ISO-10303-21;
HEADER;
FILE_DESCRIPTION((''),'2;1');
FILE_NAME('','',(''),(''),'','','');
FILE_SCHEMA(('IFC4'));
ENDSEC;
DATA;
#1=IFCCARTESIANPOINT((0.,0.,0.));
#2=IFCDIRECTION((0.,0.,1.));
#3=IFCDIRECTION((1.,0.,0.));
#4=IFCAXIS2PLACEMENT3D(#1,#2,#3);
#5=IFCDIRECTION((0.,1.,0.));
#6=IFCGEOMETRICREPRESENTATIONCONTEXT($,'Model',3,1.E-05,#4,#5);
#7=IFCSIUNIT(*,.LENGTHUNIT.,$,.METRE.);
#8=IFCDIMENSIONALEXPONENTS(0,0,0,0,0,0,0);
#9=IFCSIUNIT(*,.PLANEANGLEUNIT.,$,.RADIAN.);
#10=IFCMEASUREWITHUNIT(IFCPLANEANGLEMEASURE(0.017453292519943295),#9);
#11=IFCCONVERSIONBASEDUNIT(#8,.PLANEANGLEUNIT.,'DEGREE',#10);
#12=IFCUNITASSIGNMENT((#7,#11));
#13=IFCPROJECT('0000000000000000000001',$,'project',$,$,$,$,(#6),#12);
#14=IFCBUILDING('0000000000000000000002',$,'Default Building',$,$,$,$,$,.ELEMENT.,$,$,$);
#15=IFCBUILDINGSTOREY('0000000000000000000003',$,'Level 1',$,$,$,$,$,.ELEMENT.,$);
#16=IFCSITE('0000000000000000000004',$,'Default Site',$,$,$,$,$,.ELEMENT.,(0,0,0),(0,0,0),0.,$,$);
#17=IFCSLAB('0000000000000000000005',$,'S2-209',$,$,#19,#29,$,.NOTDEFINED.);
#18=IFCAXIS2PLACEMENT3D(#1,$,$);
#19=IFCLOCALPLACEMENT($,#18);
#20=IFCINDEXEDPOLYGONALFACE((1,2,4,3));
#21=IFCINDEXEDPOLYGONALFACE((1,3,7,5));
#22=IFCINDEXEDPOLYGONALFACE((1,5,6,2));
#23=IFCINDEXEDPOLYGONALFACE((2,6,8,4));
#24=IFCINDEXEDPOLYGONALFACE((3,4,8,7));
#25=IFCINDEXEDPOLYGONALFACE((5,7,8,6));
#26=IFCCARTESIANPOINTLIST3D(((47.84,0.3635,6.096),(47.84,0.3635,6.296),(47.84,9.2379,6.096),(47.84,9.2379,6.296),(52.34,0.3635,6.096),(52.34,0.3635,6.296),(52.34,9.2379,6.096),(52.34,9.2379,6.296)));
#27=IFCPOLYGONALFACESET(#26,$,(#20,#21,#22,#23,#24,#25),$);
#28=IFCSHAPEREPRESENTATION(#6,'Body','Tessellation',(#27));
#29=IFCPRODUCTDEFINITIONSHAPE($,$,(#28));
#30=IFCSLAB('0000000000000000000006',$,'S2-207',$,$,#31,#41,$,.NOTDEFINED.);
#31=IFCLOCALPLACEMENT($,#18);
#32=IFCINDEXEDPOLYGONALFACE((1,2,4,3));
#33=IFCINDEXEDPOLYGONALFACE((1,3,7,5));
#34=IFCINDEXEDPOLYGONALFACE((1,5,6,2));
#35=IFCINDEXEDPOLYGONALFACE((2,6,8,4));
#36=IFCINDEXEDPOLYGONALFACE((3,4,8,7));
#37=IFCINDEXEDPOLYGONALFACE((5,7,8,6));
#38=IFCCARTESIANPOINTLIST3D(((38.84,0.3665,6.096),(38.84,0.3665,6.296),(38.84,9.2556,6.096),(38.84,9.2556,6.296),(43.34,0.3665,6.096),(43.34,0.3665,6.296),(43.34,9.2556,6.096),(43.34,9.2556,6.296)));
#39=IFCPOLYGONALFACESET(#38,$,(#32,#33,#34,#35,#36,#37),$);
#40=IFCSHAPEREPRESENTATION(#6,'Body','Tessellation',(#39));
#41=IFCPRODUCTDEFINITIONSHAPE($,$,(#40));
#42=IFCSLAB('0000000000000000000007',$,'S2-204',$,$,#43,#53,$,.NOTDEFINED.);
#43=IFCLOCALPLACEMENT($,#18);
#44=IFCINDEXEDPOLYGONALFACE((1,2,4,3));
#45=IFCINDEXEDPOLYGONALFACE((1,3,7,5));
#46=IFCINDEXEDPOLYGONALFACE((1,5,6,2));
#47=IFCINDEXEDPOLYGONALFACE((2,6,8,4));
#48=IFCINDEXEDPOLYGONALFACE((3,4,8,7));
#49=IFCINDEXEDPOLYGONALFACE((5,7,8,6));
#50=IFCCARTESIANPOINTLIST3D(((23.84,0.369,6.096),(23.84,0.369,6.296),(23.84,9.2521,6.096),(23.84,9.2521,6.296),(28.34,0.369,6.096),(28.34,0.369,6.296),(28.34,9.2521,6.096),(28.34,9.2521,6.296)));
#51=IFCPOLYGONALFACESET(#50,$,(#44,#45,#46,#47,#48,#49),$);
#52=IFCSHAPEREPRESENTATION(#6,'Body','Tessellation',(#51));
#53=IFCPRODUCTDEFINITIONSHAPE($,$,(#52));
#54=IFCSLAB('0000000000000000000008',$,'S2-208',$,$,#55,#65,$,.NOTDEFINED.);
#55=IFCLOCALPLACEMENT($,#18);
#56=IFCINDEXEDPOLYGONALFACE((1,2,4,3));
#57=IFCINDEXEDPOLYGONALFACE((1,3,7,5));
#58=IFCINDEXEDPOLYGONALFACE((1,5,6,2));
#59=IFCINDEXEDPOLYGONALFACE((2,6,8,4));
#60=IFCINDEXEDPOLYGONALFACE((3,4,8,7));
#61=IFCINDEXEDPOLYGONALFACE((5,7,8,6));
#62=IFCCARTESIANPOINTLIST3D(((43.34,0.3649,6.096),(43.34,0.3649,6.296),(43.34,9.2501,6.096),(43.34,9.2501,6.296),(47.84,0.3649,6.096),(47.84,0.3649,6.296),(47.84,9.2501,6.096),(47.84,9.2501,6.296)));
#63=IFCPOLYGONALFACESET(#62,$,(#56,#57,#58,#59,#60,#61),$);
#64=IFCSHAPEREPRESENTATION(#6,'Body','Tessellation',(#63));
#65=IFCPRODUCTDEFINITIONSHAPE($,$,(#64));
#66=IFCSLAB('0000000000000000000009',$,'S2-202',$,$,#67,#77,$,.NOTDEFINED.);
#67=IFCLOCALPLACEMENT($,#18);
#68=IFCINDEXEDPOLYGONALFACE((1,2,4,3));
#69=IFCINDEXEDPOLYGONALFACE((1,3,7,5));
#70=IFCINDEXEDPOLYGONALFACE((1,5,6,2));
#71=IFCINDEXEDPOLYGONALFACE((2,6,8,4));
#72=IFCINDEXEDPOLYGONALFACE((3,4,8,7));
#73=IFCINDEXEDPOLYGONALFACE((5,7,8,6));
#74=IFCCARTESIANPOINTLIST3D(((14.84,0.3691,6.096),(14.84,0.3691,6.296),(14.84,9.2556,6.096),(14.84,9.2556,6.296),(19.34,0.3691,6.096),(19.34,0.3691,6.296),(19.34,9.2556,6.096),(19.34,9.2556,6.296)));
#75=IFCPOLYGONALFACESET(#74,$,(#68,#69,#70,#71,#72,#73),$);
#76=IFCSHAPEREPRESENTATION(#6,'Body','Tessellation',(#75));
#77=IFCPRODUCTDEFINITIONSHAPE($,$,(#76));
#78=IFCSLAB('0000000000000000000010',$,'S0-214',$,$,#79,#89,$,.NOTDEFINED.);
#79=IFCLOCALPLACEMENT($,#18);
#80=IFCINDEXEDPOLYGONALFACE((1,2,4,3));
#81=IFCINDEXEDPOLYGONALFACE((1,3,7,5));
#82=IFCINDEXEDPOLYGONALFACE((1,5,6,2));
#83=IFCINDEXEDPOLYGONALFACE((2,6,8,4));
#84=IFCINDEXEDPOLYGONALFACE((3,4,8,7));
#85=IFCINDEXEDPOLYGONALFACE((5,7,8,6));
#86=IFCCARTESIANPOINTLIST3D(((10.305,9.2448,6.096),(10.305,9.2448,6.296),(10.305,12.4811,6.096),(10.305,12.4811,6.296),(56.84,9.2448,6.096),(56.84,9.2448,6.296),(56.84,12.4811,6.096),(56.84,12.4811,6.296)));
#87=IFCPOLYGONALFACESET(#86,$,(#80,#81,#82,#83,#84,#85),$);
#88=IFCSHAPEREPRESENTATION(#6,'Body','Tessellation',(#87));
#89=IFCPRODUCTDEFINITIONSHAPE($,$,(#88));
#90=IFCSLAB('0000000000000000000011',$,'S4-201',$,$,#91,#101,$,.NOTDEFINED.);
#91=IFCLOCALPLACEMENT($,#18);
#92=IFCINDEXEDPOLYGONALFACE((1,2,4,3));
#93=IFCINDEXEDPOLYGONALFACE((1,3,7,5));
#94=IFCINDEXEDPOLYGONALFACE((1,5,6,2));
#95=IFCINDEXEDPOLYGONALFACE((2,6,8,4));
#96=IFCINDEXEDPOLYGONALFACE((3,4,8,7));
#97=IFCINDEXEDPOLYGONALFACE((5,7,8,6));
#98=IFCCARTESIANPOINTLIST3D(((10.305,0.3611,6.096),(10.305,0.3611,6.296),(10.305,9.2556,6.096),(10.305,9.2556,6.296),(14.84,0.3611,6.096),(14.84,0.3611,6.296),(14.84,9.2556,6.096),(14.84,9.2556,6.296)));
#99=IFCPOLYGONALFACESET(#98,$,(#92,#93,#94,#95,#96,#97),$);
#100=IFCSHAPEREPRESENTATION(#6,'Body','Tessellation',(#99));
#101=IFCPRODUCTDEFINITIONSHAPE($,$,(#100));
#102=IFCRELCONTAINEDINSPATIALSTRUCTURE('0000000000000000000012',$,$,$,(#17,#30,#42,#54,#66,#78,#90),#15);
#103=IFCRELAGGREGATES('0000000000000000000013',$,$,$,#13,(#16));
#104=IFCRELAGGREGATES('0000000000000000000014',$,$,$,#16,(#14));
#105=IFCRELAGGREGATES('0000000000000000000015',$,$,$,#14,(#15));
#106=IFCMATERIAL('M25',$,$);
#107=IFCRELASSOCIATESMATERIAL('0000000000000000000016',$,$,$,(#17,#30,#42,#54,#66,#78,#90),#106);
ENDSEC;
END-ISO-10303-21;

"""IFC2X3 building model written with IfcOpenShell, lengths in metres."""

from ifc_helpers import new_model, entity, si_unit, converted_unit, direction, frame, frame_2d, origin_with_axes, place, context, project, spatial, rectangle, extrude, material, element, save


model = new_model("IFC2X3")

# Units and contexts
model_context = context("Model", 3, precision=1e-05, world=origin_with_axes(), true_north=direction((0.0, 1.0, 0.0)))
ifc_project = project(units=[si_unit("LENGTHUNIT", "METRE"), converted_unit("PLANEANGLEUNIT", "DEGREE", entity("IfcPlaneAngleMeasure", 0.017453292519943295), si_unit("PLANEANGLEUNIT", "RADIAN"), dimensions=[0, 0, 0, 0, 0, 0, 0])], contexts=[model_context])

# Site, building, storey
site = spatial("IfcSite", under=ifc_project, Name="Default Site", CompositionType="ELEMENT", RefLatitude=(0, 0, 0), RefLongitude=(0, 0, 0), RefElevation=0.0)
building = spatial("IfcBuilding", under=site, Name="Default Building", CompositionType="ELEMENT")
storey = spatial("IfcBuildingStorey", under=building, Name="Level 1", CompositionType="ELEMENT")

# Shared definitions
ifc_material = material(Name="M25")
placement = place(None, origin_with_axes())

# Slabs
element("IfcSlab", 1, at=placement, inside=storey, material=ifc_material, Name="S2-209", PredefinedType="NOTDEFINED", context=model_context, shape_type="SweptSolid", body=[
    extrude(rectangle(XDim=4.5, YDim=8.8744, at=frame_2d((0.0, 0.0), x_axis=(1.0, 0.0, 0.0))), frame((50.09, 4.8007, 6.096), z_axis=(0.0, 0.0, 1.0), x_axis=(1.0, 0.0, 0.0)), (0.0, 0.0, 1.0), 0.2),
])
element("IfcSlab", 2, at=placement, inside=storey, material=ifc_material, Name="S2-207", PredefinedType="NOTDEFINED", context=model_context, shape_type="SweptSolid", body=[
    extrude(rectangle(XDim=4.5, YDim=8.8891, at=frame_2d((0.0, 0.0), x_axis=(1.0, 0.0, 0.0))), frame((41.09, 4.811, 6.096), z_axis=(0.0, 0.0, 1.0), x_axis=(1.0, 0.0, 0.0)), (0.0, 0.0, 1.0), 0.2),
])
element("IfcSlab", 3, at=placement, inside=storey, material=ifc_material, Name="S2-204", PredefinedType="NOTDEFINED", context=model_context, shape_type="SweptSolid", body=[
    extrude(rectangle(XDim=4.5, YDim=8.8831, at=frame_2d((0.0, 0.0), x_axis=(1.0, 0.0, 0.0))), frame((26.09, 4.8106, 6.096), z_axis=(0.0, 0.0, 1.0), x_axis=(1.0, 0.0, 0.0)), (0.0, 0.0, 1.0), 0.2),
])
element("IfcSlab", 4, at=placement, inside=storey, material=ifc_material, Name="S2-208", PredefinedType="NOTDEFINED", context=model_context, shape_type="SweptSolid", body=[
    extrude(rectangle(XDim=4.5, YDim=8.8852, at=frame_2d((0.0, 0.0), x_axis=(1.0, 0.0, 0.0))), frame((45.59, 4.8075, 6.096), z_axis=(0.0, 0.0, 1.0), x_axis=(1.0, 0.0, 0.0)), (0.0, 0.0, 1.0), 0.2),
])
element("IfcSlab", 5, at=placement, inside=storey, material=ifc_material, Name="S2-202", PredefinedType="NOTDEFINED", context=model_context, shape_type="SweptSolid", body=[
    extrude(rectangle(XDim=4.5, YDim=8.8865, at=frame_2d((0.0, 0.0), x_axis=(1.0, 0.0, 0.0))), frame((17.09, 4.8123, 6.096), z_axis=(0.0, 0.0, 1.0), x_axis=(1.0, 0.0, 0.0)), (0.0, 0.0, 1.0), 0.2),
])
element("IfcSlab", 6, at=placement, inside=storey, material=ifc_material, Name="S0-214", PredefinedType="NOTDEFINED", context=model_context, shape_type="SweptSolid", body=[
    extrude(rectangle(XDim=46.535, YDim=3.2363, at=frame_2d((0.0, 0.0), x_axis=(1.0, 0.0, 0.0))), frame((33.5725, 10.863, 6.096), z_axis=(0.0, 0.0, 1.0), x_axis=(1.0, 0.0, 0.0)), (0.0, 0.0, 1.0), 0.2),
])
element("IfcSlab", 7, at=placement, inside=storey, material=ifc_material, Name="S4-201", PredefinedType="NOTDEFINED", context=model_context, shape_type="SweptSolid", body=[
    extrude(rectangle(XDim=4.535, YDim=8.8945, at=frame_2d((0.0, 0.0), x_axis=(1.0, 0.0, 0.0))), frame((12.5725, 4.8083, 6.096), z_axis=(0.0, 0.0, 1.0), x_axis=(1.0, 0.0, 0.0)), (0.0, 0.0, 1.0), 0.2),
])

save(model, "model.ifc")
